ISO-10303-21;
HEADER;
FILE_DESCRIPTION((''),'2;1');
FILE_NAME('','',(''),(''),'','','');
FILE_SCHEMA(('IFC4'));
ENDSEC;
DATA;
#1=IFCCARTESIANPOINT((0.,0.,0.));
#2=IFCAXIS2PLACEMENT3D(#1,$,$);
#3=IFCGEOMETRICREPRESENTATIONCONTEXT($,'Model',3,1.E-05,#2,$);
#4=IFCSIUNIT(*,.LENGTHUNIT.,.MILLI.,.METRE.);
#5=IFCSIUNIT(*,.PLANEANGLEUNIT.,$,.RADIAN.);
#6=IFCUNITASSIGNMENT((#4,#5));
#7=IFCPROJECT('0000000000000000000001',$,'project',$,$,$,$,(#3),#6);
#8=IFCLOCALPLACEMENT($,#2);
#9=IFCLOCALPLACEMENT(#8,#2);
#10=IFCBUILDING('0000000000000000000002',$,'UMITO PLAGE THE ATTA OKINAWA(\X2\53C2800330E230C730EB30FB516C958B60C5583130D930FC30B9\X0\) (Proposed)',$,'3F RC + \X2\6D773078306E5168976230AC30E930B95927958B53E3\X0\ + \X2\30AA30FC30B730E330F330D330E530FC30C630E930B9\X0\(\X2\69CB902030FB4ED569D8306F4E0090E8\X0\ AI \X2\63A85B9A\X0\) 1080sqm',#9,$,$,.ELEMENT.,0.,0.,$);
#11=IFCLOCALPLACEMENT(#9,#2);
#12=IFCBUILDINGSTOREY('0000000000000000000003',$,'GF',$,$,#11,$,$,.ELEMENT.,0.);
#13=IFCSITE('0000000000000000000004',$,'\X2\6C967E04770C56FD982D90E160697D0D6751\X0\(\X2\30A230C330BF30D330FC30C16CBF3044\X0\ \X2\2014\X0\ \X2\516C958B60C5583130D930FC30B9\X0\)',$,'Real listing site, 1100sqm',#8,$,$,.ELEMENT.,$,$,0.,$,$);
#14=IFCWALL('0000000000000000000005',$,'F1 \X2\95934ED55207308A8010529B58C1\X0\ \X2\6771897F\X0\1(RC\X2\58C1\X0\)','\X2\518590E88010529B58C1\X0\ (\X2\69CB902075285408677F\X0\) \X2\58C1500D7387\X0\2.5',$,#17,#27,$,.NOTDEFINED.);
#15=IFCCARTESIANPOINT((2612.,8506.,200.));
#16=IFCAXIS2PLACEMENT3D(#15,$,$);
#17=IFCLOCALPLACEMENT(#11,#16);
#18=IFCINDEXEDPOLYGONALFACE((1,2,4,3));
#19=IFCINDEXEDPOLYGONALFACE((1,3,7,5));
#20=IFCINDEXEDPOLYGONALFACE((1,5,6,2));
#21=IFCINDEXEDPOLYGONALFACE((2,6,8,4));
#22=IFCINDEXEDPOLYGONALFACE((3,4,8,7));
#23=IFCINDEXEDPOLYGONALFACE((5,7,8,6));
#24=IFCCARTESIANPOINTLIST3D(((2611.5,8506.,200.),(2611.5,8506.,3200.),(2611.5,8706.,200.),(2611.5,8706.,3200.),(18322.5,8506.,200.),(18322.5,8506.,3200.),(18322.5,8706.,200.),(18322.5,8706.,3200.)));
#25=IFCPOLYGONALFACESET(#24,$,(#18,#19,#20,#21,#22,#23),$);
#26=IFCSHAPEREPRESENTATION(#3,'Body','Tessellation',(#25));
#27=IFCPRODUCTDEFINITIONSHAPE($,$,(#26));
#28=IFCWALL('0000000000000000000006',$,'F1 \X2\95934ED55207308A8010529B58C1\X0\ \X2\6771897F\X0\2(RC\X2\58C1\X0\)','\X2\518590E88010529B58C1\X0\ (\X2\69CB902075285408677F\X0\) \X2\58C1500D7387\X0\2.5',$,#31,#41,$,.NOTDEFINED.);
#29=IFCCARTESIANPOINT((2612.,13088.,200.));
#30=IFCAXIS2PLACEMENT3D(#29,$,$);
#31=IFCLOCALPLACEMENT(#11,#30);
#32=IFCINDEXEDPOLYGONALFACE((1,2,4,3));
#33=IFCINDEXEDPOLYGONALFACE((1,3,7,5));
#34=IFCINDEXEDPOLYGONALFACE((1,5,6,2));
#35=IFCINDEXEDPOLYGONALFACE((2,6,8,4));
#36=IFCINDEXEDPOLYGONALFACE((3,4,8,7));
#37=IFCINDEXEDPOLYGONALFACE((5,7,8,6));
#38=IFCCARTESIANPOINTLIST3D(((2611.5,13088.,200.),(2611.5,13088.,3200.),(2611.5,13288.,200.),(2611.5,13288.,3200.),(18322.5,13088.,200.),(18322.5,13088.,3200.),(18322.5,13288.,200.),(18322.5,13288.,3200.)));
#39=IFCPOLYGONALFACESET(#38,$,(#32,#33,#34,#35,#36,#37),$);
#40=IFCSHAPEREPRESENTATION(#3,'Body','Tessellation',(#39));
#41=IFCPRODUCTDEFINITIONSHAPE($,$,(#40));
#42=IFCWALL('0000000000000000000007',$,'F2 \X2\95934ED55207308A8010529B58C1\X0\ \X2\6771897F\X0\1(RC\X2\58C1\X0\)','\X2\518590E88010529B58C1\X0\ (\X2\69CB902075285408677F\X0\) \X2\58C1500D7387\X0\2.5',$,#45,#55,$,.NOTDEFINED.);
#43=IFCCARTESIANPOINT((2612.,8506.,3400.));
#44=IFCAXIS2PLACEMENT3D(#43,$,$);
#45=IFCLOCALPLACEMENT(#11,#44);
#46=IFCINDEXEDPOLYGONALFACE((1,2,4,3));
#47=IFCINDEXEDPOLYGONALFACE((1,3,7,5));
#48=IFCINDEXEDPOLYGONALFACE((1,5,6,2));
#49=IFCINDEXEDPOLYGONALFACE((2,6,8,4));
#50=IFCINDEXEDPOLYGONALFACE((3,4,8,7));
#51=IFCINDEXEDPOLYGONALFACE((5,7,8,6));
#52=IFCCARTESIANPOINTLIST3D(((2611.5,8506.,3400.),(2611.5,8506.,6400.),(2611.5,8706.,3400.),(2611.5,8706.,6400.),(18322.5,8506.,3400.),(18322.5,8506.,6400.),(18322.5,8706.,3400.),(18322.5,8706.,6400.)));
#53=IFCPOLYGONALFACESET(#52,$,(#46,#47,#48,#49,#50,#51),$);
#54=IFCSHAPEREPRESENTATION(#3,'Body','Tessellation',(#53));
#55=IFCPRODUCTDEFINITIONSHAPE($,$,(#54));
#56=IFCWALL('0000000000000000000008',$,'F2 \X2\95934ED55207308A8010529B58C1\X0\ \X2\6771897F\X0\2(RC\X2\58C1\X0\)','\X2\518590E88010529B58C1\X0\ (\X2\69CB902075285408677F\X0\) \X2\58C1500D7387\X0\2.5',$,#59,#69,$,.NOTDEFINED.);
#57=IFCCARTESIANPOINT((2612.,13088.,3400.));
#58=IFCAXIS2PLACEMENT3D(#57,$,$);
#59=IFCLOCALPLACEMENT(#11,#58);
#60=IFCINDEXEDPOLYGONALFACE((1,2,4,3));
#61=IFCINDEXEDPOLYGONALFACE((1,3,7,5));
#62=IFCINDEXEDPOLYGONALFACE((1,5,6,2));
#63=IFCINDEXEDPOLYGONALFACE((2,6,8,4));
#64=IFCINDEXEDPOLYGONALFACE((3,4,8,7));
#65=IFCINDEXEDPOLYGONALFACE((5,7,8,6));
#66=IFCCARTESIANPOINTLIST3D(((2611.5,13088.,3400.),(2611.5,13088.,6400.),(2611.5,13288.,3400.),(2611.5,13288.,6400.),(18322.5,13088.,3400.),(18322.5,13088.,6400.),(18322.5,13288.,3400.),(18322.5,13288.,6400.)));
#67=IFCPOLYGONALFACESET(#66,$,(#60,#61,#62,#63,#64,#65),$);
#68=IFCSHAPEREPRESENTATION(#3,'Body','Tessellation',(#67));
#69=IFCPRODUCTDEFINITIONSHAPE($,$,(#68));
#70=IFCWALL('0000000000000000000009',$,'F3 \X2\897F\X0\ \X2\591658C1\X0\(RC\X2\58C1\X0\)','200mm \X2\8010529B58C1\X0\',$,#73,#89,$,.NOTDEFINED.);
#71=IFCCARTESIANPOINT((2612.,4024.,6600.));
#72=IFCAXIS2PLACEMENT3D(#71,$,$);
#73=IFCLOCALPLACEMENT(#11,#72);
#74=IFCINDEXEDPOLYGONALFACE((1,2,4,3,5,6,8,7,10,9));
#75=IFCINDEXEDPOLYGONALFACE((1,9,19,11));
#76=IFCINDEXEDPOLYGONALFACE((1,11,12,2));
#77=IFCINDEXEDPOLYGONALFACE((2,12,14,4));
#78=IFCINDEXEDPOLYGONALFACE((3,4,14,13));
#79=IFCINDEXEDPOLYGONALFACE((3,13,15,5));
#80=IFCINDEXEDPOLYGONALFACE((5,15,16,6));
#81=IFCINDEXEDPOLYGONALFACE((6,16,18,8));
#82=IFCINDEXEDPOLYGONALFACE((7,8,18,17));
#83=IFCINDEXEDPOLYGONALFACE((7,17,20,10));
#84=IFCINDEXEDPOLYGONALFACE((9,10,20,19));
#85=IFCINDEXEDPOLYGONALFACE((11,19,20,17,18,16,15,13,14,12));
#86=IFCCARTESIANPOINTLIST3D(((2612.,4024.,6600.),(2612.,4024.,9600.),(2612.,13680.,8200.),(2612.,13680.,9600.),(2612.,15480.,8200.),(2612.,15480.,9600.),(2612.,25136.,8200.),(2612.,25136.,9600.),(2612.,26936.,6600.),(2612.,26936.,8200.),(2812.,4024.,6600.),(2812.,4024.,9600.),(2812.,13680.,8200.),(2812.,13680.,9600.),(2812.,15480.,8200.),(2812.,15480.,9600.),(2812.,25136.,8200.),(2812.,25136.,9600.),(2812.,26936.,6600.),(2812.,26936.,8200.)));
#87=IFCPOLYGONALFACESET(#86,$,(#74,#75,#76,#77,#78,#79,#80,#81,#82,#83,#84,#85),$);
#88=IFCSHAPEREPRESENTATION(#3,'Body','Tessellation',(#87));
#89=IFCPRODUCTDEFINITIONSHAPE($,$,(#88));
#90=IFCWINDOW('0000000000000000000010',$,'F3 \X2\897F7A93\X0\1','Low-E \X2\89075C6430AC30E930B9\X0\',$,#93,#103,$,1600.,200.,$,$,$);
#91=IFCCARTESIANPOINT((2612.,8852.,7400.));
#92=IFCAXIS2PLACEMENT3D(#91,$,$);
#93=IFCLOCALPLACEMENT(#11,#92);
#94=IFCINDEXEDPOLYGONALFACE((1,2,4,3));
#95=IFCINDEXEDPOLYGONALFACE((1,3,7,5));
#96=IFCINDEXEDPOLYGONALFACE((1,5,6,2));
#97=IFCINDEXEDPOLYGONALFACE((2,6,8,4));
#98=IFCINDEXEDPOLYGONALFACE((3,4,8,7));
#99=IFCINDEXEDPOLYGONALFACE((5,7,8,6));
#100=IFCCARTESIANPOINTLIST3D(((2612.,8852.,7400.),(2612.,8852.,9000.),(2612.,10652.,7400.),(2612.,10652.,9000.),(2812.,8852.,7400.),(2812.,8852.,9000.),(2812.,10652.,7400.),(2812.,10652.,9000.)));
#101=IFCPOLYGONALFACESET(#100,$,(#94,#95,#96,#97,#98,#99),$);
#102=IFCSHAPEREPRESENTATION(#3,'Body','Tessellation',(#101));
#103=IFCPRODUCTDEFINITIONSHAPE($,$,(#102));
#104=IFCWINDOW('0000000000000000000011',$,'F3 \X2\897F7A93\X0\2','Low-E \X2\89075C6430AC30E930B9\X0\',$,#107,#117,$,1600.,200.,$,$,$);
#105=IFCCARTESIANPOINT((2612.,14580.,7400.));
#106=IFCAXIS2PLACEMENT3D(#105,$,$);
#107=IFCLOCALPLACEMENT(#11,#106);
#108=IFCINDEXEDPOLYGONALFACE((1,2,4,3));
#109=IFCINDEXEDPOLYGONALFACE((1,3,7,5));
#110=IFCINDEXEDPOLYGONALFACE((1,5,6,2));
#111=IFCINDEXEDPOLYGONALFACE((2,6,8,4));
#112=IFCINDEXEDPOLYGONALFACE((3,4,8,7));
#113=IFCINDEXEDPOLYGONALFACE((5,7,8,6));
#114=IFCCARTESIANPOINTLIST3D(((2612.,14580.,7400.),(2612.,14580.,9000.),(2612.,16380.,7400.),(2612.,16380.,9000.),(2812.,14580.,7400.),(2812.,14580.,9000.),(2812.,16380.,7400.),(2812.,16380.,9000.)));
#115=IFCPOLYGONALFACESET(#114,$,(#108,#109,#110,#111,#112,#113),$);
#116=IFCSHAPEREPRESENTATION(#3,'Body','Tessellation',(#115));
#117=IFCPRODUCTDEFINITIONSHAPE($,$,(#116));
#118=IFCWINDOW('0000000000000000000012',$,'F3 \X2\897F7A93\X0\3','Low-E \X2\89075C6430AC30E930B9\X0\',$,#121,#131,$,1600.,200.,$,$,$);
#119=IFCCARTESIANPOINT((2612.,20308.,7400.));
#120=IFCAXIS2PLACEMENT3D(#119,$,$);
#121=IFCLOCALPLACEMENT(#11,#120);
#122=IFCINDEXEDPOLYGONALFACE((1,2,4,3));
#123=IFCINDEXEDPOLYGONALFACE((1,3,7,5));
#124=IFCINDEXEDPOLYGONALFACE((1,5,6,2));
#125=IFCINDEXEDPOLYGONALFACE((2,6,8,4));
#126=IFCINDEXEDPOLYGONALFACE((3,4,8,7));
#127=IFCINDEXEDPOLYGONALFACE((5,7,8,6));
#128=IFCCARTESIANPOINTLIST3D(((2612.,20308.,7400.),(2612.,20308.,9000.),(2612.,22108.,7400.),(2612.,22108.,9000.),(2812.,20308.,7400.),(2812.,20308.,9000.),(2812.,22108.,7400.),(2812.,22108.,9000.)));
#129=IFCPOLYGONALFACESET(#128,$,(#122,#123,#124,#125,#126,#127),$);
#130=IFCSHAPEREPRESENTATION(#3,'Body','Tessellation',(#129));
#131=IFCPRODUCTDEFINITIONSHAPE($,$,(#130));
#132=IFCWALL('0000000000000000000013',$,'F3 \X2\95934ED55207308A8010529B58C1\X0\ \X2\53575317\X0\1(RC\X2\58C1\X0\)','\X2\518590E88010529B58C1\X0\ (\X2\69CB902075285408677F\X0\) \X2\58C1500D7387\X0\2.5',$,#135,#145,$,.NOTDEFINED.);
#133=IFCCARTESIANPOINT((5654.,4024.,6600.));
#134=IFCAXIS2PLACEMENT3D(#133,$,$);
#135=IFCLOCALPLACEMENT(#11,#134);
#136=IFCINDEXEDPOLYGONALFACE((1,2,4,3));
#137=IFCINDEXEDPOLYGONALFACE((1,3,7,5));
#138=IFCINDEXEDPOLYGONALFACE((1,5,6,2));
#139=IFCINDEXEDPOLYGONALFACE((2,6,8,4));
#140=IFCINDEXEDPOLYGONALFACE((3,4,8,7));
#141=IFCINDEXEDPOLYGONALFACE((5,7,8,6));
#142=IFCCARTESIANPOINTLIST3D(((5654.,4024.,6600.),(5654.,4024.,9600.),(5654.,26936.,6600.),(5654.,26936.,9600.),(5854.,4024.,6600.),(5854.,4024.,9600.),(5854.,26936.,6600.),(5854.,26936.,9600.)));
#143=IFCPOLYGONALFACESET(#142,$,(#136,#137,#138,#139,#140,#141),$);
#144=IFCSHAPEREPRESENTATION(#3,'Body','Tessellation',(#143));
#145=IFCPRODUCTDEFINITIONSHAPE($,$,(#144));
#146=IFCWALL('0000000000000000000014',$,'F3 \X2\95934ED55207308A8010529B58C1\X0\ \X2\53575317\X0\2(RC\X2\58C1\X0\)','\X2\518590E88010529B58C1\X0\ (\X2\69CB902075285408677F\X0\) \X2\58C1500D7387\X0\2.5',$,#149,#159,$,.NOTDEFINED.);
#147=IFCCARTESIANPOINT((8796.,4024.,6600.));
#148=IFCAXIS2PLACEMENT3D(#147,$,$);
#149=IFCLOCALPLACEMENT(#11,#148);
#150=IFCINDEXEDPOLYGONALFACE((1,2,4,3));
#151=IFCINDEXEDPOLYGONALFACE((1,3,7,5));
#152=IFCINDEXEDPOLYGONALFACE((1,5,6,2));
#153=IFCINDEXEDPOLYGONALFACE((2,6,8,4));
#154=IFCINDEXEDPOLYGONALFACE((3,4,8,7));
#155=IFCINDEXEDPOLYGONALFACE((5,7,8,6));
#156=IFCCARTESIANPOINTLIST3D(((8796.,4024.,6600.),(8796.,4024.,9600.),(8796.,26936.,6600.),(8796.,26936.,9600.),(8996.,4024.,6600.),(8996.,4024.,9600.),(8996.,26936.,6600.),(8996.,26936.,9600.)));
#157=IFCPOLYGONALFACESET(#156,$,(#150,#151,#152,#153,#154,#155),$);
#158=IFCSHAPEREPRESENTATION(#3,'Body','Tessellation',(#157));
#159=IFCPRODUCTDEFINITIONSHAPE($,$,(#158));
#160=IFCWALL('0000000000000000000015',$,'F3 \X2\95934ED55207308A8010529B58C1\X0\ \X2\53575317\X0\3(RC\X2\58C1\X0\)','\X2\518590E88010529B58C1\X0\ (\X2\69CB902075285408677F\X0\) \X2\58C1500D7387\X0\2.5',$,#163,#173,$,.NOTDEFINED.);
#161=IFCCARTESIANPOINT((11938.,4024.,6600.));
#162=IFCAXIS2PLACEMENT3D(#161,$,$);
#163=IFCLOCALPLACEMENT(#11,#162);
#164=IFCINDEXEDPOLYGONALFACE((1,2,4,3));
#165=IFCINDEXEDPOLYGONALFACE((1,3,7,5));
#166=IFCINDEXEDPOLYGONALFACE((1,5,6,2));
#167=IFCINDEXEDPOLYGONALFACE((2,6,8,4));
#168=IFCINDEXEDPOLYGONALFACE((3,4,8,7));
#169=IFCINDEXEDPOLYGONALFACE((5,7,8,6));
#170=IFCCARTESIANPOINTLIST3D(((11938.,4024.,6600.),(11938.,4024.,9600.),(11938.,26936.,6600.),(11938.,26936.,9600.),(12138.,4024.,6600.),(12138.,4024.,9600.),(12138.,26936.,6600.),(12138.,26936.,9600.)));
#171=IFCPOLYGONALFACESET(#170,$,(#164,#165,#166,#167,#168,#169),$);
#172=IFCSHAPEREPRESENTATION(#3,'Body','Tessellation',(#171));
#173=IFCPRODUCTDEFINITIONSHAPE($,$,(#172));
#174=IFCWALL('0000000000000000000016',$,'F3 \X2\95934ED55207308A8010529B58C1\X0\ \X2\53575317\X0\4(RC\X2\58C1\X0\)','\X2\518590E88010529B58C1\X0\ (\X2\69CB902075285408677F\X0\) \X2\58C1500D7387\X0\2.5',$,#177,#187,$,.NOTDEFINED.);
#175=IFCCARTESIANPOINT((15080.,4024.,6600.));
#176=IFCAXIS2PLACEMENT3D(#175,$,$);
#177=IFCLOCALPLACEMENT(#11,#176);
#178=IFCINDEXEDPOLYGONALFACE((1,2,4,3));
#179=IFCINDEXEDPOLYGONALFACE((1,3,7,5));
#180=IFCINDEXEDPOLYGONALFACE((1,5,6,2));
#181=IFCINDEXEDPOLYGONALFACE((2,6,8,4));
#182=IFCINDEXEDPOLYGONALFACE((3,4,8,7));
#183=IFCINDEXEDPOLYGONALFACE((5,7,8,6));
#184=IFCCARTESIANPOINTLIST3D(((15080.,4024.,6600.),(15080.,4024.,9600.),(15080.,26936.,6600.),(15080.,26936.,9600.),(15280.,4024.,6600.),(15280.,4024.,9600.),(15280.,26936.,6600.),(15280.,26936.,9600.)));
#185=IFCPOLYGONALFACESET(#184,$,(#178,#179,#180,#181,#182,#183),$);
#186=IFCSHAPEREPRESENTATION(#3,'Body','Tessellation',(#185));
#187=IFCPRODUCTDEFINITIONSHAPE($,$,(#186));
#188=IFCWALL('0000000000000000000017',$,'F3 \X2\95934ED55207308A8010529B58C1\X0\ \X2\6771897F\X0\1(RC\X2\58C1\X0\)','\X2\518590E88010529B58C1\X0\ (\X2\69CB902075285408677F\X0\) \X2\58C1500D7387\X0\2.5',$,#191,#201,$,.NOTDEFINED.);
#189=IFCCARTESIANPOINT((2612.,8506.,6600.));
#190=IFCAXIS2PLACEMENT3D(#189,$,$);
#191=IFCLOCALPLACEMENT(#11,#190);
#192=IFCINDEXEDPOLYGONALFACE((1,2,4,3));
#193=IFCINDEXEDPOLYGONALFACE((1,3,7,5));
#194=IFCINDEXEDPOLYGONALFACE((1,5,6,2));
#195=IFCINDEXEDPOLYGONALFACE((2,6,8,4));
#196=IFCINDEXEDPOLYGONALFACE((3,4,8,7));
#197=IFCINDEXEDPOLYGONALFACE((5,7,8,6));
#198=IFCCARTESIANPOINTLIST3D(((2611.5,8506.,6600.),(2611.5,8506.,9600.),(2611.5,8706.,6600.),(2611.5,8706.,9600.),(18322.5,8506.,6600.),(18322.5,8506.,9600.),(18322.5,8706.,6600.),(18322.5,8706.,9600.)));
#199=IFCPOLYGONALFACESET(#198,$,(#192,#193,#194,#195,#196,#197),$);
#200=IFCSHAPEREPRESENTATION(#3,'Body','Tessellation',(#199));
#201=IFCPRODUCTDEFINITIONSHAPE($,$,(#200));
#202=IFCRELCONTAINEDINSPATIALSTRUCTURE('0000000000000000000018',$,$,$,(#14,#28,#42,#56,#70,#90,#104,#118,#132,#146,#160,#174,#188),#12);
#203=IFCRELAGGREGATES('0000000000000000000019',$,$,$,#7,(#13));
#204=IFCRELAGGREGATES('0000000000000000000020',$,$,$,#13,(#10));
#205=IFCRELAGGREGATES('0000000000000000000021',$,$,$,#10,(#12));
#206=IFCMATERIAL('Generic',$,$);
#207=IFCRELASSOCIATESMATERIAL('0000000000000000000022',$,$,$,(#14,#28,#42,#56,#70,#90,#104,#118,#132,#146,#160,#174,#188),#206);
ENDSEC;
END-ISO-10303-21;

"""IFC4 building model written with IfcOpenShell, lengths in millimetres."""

from ifc_helpers import new_model, si_unit, frame, frame_2d, origin, place, context, project, spatial, rectangle, extrude, material, element, fill, save


model = new_model("IFC4")

# Units and contexts
model_context = context("Model", 3, precision=1e-05, world=origin())
ifc_project = project(units=[si_unit("LENGTHUNIT", "METRE", prefix="MILLI"), si_unit("PLANEANGLEUNIT", "RADIAN")], contexts=[model_context])

# Site, building, storey
site_placement = place(None, origin())
site = spatial("IfcSite", under=ifc_project, at=site_placement, Name="沖縄県国頭郡恩納村(アッタビーチ沿い — 公開情報ベース)", ObjectType="Real listing site, 1100sqm", CompositionType="ELEMENT", RefElevation=0.0)
building_placement = place(site_placement, origin())
building = spatial("IfcBuilding", under=site, at=building_placement, Name="UMITO PLAGE THE ATTA OKINAWA(参考モデル・公開情報ベース) (Proposed)", ObjectType="3F RC + 海への全面ガラス大開口 + オーシャンビューテラス(構造・仕様は一部 AI 推定) 1080sqm", CompositionType="ELEMENT", ElevationOfRefHeight=0.0, ElevationOfTerrain=0.0)
storey_placement = place(building_placement, origin())
storey = spatial("IfcBuildingStorey", under=building, at=storey_placement, Name="GF", CompositionType="ELEMENT", Elevation=0.0)

# Walls
ifc_material = material(Name="Generic")
wall_1_placement = place(storey_placement, frame((2612.0, 8506.0, 200.0)))
element("IfcWall", 1, at=wall_1_placement, inside=storey, material=ifc_material, Name="F1 間仕切り耐力壁 東西1(RC壁)", Description="内部耐力壁 (構造用合板) 壁倍率2.5", PredefinedType="NOTDEFINED", context=model_context, shape_type="SweptSolid", body=[
    extrude(rectangle(XDim=15711.0, YDim=200.0, at=frame_2d((7855.0, 100.0))), frame((2612.0, 8506.0, 200.0)), (0.0, 0.0, 1.0), 3000.0),
])
wall_2_placement = place(storey_placement, frame((2612.0, 13088.0, 200.0)))
element("IfcWall", 2, at=wall_2_placement, inside=storey, material=ifc_material, Name="F1 間仕切り耐力壁 東西2(RC壁)", Description="内部耐力壁 (構造用合板) 壁倍率2.5", PredefinedType="NOTDEFINED", context=model_context, shape_type="SweptSolid", body=[
    extrude(rectangle(XDim=15711.0, YDim=200.0, at=frame_2d((7855.0, 100.0))), frame((2612.0, 13088.0, 200.0)), (0.0, 0.0, 1.0), 3000.0),
])
wall_3_placement = place(storey_placement, frame((2612.0, 8506.0, 3400.0)))
element("IfcWall", 3, at=wall_3_placement, inside=storey, material=ifc_material, Name="F2 間仕切り耐力壁 東西1(RC壁)", Description="内部耐力壁 (構造用合板) 壁倍率2.5", PredefinedType="NOTDEFINED", context=model_context, shape_type="SweptSolid", body=[
    extrude(rectangle(XDim=15711.0, YDim=200.0, at=frame_2d((7855.0, 100.0))), frame((2612.0, 8506.0, 3400.0)), (0.0, 0.0, 1.0), 3000.0),
])
wall_4_placement = place(storey_placement, frame((2612.0, 13088.0, 3400.0)))
element("IfcWall", 4, at=wall_4_placement, inside=storey, material=ifc_material, Name="F2 間仕切り耐力壁 東西2(RC壁)", Description="内部耐力壁 (構造用合板) 壁倍率2.5", PredefinedType="NOTDEFINED", context=model_context, shape_type="SweptSolid", body=[
    extrude(rectangle(XDim=15711.0, YDim=200.0, at=frame_2d((7855.0, 100.0))), frame((2612.0, 13088.0, 3400.0)), (0.0, 0.0, 1.0), 3000.0),
])

# Wall, openings, windows
wall_5_placement = place(storey_placement, frame((2612.0, 4024.0, 6600.0)))
wall_5 = element("IfcWall", 5, at=wall_5_placement, inside=storey, material=ifc_material, Name="F3 西 外壁(RC壁)", Description="200mm 耐力壁", PredefinedType="NOTDEFINED", context=model_context, shape_type="SweptSolid", body=[
    extrude(rectangle(XDim=200.0, YDim=22912.0, at=frame_2d((100.0, 11456.0))), frame((2612.0, 4024.0, 6600.0)), (0.0, 0.0, 1.0), 3000.0),
])
opening_1_placement = place(storey_placement, frame((2612.0, 8852.0, 7400.0)))
opening_1 = element("IfcOpeningElement", 6, at=opening_1_placement, cuts=wall_5, PredefinedType="NOTDEFINED", context=model_context, shape_type="SweptSolid", body=[
    extrude(rectangle(XDim=200.0, YDim=1800.0, at=frame_2d((100.0, 900.0))), frame((2612.0, 8852.0, 7400.0)), (0.0, 0.0, 1.0), 1600.0),
])
opening_2_placement = place(storey_placement, frame((2612.0, 14580.0, 7400.0)))
opening_2 = element("IfcOpeningElement", 7, at=opening_2_placement, cuts=wall_5, PredefinedType="NOTDEFINED", context=model_context, shape_type="SweptSolid", body=[
    extrude(rectangle(XDim=200.0, YDim=1800.0, at=frame_2d((100.0, 900.0))), frame((2612.0, 14580.0, 7400.0)), (0.0, 0.0, 1.0), 1600.0),
])
opening_3_placement = place(storey_placement, frame((2612.0, 20308.0, 7400.0)))
opening_3 = element("IfcOpeningElement", 8, at=opening_3_placement, cuts=wall_5, PredefinedType="NOTDEFINED", context=model_context, shape_type="SweptSolid", body=[
    extrude(rectangle(XDim=200.0, YDim=1800.0, at=frame_2d((100.0, 900.0))), frame((2612.0, 20308.0, 7400.0)), (0.0, 0.0, 1.0), 1600.0),
])
window_1_placement = place(storey_placement, frame((2612.0, 8852.0, 7400.0)))
window_1 = element("IfcWindow", 9, at=window_1_placement, inside=storey, material=ifc_material, Name="F3 西窓1", Description="Low-E 複層ガラス", OverallHeight=1600.0, OverallWidth=200.0, context=model_context, shape_type="SweptSolid", body=[
    extrude(rectangle(XDim=200.0, YDim=1800.0, at=frame_2d((100.0, 900.0))), frame((2612.0, 8852.0, 7400.0)), (0.0, 0.0, 1.0), 1600.0),
])
fill(opening_1, window_1)
window_2_placement = place(storey_placement, frame((2612.0, 14580.0, 7400.0)))
window_2 = element("IfcWindow", 10, at=window_2_placement, inside=storey, material=ifc_material, Name="F3 西窓2", Description="Low-E 複層ガラス", OverallHeight=1600.0, OverallWidth=200.0, context=model_context, shape_type="SweptSolid", body=[
    extrude(rectangle(XDim=200.0, YDim=1800.0, at=frame_2d((100.0, 900.0))), frame((2612.0, 14580.0, 7400.0)), (0.0, 0.0, 1.0), 1600.0),
])
fill(opening_2, window_2)
window_3_placement = place(storey_placement, frame((2612.0, 20308.0, 7400.0)))
window_3 = element("IfcWindow", 11, at=window_3_placement, inside=storey, material=ifc_material, Name="F3 西窓3", Description="Low-E 複層ガラス", OverallHeight=1600.0, OverallWidth=200.0, context=model_context, shape_type="SweptSolid", body=[
    extrude(rectangle(XDim=200.0, YDim=1800.0, at=frame_2d((100.0, 900.0))), frame((2612.0, 20308.0, 7400.0)), (0.0, 0.0, 1.0), 1600.0),
])
fill(opening_3, window_3)

# Walls
wall_6_placement = place(storey_placement, frame((5654.0, 4024.0, 6600.0)))
element("IfcWall", 12, at=wall_6_placement, inside=storey, material=ifc_material, Name="F3 間仕切り耐力壁 南北1(RC壁)", Description="内部耐力壁 (構造用合板) 壁倍率2.5", PredefinedType="NOTDEFINED", context=model_context, shape_type="SweptSolid", body=[
    extrude(rectangle(XDim=200.0, YDim=22912.0, at=frame_2d((100.0, 11456.0))), frame((5654.0, 4024.0, 6600.0)), (0.0, 0.0, 1.0), 3000.0),
])
wall_7_placement = place(storey_placement, frame((8796.0, 4024.0, 6600.0)))
element("IfcWall", 13, at=wall_7_placement, inside=storey, material=ifc_material, Name="F3 間仕切り耐力壁 南北2(RC壁)", Description="内部耐力壁 (構造用合板) 壁倍率2.5", PredefinedType="NOTDEFINED", context=model_context, shape_type="SweptSolid", body=[
    extrude(rectangle(XDim=200.0, YDim=22912.0, at=frame_2d((100.0, 11456.0))), frame((8796.0, 4024.0, 6600.0)), (0.0, 0.0, 1.0), 3000.0),
])
wall_8_placement = place(storey_placement, frame((11938.0, 4024.0, 6600.0)))
element("IfcWall", 14, at=wall_8_placement, inside=storey, material=ifc_material, Name="F3 間仕切り耐力壁 南北3(RC壁)", Description="内部耐力壁 (構造用合板) 壁倍率2.5", PredefinedType="NOTDEFINED", context=model_context, shape_type="SweptSolid", body=[
    extrude(rectangle(XDim=200.0, YDim=22912.0, at=frame_2d((100.0, 11456.0))), frame((11938.0, 4024.0, 6600.0)), (0.0, 0.0, 1.0), 3000.0),
])
wall_9_placement = place(storey_placement, frame((15080.0, 4024.0, 6600.0)))
element("IfcWall", 15, at=wall_9_placement, inside=storey, material=ifc_material, Name="F3 間仕切り耐力壁 南北4(RC壁)", Description="内部耐力壁 (構造用合板) 壁倍率2.5", PredefinedType="NOTDEFINED", context=model_context, shape_type="SweptSolid", body=[
    extrude(rectangle(XDim=200.0, YDim=22912.0, at=frame_2d((100.0, 11456.0))), frame((15080.0, 4024.0, 6600.0)), (0.0, 0.0, 1.0), 3000.0),
])
wall_10_placement = place(storey_placement, frame((2612.0, 8506.0, 6600.0)))
element("IfcWall", 16, at=wall_10_placement, inside=storey, material=ifc_material, Name="F3 間仕切り耐力壁 東西1(RC壁)", Description="内部耐力壁 (構造用合板) 壁倍率2.5", PredefinedType="NOTDEFINED", context=model_context, shape_type="SweptSolid", body=[
    extrude(rectangle(XDim=15711.0, YDim=200.0, at=frame_2d((7855.0, 100.0))), frame((2612.0, 8506.0, 6600.0)), (0.0, 0.0, 1.0), 3000.0),
])

save(model, "model.ifc")
